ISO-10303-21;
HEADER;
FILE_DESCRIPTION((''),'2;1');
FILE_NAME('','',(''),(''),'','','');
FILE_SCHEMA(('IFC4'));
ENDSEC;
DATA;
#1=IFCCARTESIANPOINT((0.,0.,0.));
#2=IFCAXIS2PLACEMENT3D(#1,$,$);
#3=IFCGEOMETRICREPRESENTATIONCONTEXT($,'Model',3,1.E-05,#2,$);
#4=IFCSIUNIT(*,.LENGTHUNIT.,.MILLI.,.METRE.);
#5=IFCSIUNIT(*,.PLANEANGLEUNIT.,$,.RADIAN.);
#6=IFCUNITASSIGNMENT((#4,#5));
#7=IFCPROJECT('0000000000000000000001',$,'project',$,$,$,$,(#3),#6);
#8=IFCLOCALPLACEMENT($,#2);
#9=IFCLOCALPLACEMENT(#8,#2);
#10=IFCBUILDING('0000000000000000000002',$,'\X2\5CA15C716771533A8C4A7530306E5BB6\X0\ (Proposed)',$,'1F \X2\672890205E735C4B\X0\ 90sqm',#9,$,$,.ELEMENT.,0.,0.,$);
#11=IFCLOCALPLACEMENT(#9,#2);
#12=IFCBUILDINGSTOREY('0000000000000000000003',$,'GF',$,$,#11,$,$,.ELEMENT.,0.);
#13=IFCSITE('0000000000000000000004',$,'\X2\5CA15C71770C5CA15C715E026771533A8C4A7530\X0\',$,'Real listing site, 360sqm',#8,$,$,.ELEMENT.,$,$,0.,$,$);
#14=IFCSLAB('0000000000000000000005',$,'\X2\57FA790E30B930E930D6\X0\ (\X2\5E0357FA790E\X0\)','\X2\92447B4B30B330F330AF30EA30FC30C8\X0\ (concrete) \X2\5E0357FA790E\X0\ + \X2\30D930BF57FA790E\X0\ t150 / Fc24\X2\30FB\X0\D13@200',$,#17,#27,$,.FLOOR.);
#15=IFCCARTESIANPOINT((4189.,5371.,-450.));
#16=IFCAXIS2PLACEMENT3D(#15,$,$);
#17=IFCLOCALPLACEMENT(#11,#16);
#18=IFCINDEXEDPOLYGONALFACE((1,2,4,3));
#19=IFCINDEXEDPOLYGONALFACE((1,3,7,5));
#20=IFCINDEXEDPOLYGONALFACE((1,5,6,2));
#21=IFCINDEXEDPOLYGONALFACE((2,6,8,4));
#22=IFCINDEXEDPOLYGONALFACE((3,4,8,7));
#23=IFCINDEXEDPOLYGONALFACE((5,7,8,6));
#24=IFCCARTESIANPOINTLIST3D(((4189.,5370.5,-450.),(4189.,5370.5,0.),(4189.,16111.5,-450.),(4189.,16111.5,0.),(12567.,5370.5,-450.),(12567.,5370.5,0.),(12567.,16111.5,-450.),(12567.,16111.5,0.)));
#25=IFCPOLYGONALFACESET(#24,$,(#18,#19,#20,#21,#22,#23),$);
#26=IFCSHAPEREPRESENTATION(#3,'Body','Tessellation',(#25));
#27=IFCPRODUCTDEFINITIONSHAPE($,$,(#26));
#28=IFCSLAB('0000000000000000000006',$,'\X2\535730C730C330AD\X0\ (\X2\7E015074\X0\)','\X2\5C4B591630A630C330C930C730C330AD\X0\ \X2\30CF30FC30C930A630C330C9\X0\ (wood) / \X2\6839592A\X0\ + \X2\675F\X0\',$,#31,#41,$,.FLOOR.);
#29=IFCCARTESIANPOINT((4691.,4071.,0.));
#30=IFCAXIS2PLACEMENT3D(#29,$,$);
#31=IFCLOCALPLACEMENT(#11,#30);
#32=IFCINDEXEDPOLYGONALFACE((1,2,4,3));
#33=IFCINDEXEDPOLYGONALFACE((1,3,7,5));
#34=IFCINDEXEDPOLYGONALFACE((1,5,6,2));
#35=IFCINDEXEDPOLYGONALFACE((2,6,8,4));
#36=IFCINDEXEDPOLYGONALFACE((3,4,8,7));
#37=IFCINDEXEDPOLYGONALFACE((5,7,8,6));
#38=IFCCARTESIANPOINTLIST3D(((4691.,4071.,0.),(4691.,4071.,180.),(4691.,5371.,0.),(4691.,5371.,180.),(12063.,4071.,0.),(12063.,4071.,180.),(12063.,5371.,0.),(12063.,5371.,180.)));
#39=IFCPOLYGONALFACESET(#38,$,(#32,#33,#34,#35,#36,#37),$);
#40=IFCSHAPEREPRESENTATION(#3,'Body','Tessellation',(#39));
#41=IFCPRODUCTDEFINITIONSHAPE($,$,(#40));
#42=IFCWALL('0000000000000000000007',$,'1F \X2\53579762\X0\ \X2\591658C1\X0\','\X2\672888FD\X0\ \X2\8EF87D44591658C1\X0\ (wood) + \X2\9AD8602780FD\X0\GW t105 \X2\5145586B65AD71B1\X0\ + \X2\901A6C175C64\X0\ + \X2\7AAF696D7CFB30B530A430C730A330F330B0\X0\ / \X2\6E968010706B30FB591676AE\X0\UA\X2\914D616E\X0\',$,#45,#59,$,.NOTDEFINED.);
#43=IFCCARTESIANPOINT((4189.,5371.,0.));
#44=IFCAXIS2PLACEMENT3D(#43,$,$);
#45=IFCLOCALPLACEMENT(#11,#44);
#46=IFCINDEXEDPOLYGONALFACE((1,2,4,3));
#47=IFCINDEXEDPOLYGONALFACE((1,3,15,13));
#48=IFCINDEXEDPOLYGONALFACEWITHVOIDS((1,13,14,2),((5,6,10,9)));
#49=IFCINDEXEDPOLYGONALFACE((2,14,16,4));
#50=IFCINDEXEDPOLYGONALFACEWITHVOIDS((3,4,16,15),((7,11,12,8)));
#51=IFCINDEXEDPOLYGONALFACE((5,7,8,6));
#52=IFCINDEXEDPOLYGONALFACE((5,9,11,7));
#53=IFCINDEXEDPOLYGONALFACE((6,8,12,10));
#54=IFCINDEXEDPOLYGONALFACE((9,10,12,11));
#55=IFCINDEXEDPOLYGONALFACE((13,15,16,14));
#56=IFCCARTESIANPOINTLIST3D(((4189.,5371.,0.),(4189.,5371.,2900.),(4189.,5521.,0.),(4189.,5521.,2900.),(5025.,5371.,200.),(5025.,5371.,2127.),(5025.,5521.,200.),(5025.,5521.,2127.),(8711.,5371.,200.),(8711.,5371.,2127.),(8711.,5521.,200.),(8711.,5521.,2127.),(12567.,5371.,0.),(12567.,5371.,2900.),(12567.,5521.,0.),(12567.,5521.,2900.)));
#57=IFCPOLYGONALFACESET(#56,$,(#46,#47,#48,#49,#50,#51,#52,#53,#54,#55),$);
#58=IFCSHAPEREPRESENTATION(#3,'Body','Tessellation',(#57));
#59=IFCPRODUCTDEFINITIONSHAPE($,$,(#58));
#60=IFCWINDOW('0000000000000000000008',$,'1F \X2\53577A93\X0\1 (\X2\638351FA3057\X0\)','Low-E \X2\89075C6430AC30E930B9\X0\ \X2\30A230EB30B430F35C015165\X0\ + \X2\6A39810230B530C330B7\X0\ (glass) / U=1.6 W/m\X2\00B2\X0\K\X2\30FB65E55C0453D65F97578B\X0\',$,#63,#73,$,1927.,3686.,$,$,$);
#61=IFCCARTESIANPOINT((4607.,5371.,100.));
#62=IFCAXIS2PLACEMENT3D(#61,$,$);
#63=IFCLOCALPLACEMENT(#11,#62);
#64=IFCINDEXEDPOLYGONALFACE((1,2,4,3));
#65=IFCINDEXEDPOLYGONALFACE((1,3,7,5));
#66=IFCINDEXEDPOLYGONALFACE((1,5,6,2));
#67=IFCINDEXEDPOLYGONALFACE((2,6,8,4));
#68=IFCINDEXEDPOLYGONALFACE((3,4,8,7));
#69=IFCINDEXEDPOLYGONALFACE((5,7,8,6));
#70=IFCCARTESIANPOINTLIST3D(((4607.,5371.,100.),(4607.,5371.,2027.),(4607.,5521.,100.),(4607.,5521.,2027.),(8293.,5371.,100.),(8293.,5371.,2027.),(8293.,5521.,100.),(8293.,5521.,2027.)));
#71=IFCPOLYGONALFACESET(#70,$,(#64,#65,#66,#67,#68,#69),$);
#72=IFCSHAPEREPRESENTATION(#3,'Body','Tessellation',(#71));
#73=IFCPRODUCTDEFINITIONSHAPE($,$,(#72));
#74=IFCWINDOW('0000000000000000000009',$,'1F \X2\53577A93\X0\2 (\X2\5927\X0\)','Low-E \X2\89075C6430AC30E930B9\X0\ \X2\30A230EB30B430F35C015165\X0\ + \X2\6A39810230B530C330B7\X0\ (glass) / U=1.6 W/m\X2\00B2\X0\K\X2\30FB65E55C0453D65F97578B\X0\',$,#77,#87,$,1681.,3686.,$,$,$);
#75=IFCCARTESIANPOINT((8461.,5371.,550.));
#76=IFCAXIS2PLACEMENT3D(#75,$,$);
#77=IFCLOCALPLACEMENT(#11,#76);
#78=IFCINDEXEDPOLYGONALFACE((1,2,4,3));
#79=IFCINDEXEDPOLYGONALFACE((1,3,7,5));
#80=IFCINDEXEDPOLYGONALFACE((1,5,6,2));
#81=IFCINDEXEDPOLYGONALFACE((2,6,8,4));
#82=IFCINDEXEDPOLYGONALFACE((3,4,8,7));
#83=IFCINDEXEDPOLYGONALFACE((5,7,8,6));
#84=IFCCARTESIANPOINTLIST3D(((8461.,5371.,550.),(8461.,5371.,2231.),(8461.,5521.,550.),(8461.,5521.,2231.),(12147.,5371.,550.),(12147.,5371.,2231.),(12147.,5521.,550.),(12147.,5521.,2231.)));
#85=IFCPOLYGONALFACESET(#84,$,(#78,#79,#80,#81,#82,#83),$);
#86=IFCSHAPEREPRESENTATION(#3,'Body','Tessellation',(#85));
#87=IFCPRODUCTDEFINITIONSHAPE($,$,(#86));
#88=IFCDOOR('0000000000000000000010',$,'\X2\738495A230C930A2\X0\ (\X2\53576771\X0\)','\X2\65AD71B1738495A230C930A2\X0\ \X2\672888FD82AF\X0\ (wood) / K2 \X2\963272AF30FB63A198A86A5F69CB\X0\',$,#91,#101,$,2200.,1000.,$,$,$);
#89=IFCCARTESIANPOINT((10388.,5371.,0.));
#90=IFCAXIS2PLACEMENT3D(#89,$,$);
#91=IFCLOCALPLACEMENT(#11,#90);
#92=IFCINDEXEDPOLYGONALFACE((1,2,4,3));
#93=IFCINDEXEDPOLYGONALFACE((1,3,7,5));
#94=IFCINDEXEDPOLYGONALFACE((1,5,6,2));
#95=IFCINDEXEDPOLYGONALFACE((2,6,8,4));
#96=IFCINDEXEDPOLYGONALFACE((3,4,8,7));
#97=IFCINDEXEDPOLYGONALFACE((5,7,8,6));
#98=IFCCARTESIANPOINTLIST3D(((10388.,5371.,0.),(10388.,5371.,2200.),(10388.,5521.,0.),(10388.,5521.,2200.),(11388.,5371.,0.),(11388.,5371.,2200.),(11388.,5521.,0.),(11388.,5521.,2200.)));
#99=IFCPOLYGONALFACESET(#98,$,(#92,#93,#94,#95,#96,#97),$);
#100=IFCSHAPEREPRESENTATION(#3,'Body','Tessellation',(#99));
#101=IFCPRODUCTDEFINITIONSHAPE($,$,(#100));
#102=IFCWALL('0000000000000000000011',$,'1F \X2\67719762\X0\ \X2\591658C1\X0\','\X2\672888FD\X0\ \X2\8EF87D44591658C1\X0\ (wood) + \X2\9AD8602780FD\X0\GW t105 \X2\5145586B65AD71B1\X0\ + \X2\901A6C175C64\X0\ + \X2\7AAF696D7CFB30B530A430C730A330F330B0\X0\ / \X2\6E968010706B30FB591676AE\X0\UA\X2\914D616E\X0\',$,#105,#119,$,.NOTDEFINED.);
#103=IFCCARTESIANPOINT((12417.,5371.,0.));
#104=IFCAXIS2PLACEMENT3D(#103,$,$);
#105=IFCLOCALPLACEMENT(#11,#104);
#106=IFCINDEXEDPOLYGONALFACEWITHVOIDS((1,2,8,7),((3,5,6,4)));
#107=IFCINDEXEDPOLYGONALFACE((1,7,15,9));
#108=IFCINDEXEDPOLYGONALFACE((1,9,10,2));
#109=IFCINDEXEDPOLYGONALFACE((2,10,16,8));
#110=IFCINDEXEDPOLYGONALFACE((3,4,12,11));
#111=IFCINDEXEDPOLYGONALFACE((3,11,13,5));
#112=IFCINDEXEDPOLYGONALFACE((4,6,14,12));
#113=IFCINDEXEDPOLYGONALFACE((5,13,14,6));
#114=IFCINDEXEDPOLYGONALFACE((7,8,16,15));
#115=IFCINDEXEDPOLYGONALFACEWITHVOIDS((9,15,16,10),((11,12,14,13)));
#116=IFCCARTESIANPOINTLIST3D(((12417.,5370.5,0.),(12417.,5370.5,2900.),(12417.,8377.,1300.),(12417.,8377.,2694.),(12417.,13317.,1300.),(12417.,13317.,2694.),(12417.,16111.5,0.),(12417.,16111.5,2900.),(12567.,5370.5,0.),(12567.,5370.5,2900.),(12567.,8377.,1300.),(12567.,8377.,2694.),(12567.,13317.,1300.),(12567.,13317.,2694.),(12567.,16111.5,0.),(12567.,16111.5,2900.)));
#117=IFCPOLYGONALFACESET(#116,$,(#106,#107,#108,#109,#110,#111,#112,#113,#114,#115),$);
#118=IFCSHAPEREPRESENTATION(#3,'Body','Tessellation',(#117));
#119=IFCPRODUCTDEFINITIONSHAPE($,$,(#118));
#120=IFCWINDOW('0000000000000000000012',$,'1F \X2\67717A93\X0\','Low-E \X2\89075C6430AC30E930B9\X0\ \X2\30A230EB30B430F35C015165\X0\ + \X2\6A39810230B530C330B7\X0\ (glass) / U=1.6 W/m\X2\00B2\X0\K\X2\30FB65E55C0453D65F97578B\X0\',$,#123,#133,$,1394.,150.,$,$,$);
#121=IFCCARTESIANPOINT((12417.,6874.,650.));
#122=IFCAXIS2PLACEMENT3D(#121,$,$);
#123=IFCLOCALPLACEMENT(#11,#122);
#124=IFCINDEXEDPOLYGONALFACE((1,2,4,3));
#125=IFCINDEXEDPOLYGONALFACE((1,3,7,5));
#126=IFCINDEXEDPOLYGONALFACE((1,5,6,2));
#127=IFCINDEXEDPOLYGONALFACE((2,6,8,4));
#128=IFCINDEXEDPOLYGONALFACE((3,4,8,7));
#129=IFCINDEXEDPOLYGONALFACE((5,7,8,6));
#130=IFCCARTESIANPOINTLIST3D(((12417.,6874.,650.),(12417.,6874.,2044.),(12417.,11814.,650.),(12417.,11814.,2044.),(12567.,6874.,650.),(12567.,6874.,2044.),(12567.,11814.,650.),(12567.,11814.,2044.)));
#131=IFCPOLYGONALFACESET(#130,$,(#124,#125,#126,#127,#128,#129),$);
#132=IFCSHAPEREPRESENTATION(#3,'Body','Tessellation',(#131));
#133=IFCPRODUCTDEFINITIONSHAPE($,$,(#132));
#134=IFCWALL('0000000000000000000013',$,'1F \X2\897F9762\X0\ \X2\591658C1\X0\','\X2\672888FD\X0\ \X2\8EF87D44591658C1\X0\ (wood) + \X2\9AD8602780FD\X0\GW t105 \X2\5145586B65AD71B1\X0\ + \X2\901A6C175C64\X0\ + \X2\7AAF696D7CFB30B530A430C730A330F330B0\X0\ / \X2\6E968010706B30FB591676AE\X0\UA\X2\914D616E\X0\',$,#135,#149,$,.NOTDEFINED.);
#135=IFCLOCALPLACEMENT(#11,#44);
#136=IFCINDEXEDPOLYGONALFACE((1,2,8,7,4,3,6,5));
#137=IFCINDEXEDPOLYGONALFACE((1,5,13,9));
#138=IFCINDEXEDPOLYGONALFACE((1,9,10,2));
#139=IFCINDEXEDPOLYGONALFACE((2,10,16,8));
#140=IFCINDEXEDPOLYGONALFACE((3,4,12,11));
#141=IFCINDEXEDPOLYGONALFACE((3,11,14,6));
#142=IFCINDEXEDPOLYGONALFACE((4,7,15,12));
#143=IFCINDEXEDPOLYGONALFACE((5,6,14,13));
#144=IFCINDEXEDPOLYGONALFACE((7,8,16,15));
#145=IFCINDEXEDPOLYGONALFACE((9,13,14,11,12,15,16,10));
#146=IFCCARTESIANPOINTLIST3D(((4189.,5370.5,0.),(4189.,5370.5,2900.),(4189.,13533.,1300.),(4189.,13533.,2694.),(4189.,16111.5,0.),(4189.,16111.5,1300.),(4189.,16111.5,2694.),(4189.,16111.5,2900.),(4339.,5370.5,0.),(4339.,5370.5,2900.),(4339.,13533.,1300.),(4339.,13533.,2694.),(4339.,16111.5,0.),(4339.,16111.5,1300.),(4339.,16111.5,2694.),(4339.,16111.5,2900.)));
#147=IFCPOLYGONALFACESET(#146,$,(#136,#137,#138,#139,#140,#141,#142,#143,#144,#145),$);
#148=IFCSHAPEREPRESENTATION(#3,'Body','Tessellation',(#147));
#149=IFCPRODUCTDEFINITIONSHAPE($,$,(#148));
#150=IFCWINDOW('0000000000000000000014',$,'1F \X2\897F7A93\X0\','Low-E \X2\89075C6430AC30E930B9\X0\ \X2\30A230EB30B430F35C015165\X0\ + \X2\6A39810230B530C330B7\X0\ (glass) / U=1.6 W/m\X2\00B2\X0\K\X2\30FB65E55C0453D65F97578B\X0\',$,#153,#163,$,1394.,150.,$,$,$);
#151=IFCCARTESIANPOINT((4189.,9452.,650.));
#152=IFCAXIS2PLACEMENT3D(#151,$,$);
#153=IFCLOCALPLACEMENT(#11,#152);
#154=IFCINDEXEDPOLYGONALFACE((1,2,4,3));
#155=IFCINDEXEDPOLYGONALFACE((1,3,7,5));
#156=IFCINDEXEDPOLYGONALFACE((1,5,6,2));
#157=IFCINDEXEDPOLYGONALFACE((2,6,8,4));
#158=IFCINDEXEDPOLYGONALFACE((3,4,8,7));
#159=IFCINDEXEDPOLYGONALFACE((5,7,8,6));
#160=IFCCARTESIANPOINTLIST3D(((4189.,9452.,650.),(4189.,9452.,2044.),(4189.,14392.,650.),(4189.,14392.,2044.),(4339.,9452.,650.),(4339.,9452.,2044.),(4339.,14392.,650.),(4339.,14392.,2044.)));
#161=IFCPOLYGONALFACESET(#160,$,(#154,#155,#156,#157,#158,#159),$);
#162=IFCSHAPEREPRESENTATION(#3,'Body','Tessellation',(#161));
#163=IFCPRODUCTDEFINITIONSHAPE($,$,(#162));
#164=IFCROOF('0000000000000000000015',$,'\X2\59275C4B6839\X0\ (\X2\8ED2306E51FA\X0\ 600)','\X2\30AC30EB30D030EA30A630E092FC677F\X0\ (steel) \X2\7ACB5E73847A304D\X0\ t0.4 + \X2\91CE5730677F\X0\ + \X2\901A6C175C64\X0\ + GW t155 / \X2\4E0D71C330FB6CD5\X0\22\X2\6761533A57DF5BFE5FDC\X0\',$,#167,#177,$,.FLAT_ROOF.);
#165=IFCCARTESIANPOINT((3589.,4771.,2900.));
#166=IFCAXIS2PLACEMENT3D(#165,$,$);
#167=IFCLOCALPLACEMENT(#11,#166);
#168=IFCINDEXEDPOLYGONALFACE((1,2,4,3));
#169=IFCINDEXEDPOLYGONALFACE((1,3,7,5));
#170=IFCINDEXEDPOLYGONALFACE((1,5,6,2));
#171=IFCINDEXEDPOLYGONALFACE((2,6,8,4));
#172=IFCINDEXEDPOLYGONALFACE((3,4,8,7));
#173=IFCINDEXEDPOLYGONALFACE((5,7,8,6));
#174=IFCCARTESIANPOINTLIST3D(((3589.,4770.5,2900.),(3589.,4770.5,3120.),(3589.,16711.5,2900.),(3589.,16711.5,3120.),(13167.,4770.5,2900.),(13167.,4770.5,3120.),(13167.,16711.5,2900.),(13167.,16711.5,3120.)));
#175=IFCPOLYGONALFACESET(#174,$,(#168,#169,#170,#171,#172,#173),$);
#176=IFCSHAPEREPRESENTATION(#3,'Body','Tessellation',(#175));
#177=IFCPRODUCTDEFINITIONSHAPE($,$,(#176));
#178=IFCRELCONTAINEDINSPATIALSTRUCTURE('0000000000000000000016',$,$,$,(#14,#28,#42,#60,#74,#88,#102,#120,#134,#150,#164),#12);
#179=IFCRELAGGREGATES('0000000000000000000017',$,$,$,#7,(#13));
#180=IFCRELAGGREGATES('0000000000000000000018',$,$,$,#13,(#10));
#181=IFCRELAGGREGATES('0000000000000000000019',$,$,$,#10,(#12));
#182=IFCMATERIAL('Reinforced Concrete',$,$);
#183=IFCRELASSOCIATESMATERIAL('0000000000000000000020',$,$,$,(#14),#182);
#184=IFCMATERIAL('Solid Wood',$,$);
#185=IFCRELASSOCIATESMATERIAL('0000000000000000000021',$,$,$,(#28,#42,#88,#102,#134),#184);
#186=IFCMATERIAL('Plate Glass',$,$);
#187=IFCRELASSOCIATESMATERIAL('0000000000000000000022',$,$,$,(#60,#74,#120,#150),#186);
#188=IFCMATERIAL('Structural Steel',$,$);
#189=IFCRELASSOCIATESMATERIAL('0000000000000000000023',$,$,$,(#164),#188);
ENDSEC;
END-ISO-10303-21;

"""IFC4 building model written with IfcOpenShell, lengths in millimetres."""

from ifc_helpers import new_model, si_unit, frame, frame_2d, origin, place, context, project, spatial, rectangle, extrude, material, element, fill, save


model = new_model("IFC4")

# Units and contexts
model_context = context("Model", 3, precision=1e-05, world=origin())
ifc_project = project(units=[si_unit("LENGTHUNIT", "METRE", prefix="MILLI"), si_unit("PLANEANGLEUNIT", "RADIAN")], contexts=[model_context])

# Site, building, storey
site_placement = place(None, origin())
site = spatial("IfcSite", under=ifc_project, at=site_placement, Name="岡山県岡山市東区豊田", ObjectType="Real listing site, 360sqm", CompositionType="ELEMENT", RefElevation=0.0)
building_placement = place(site_placement, origin())
building = spatial("IfcBuilding", under=site, at=building_placement, Name="岡山東区豊田の家 (Proposed)", ObjectType="1F 木造平屋 90sqm", CompositionType="ELEMENT", ElevationOfRefHeight=0.0, ElevationOfTerrain=0.0)
storey_placement = place(building_placement, origin())
storey = spatial("IfcBuildingStorey", under=building, at=storey_placement, Name="GF", CompositionType="ELEMENT", Elevation=0.0)

# Slabs
ifc_material_1 = material(Name="Reinforced Concrete")
slab_1_placement = place(storey_placement, frame((4189.0, 5371.0, -450.0)))
element("IfcSlab", 1, at=slab_1_placement, inside=storey, material=ifc_material_1, Name="基礎スラブ (布基礎)", Description="鉄筋コンクリート (concrete) 布基礎 + ベタ基礎 t150 / Fc24・D13@200", PredefinedType="FLOOR", context=model_context, shape_type="SweptSolid", body=[
    extrude(rectangle(XDim=8378.0, YDim=10741.0, at=frame_2d((4189.0, 5370.0))), frame((4189.0, 5371.0, -450.0)), (0.0, 0.0, 1.0), 450.0),
])
ifc_material_2 = material(Name="Solid Wood")
slab_2_placement = place(storey_placement, frame((4691.0, 4071.0, 0.0)))
element("IfcSlab", 2, at=slab_2_placement, inside=storey, material=ifc_material_2, Name="南デッキ (縁側)", Description="屋外ウッドデッキ ハードウッド (wood) / 根太 + 束", PredefinedType="FLOOR", context=model_context, shape_type="SweptSolid", body=[
    extrude(rectangle(XDim=7372.0, YDim=1300.0, at=frame_2d((3686.0, 650.0))), frame((4691.0, 4071.0, 0.0)), (0.0, 0.0, 1.0), 180.0),
])

# Wall, openings, windows, door
wall_1_placement = place(storey_placement, frame((4189.0, 5371.0, 0.0)))
wall_1 = element("IfcWall", 3, at=wall_1_placement, inside=storey, material=ifc_material_2, Name="1F 南面 外壁", Description="木製 軸組外壁 (wood) + 高性能GW t105 充填断熱 + 通気層 + 窯業系サイディング / 準耐火・外皮UA配慮", PredefinedType="NOTDEFINED", context=model_context, shape_type="SweptSolid", body=[
    extrude(rectangle(XDim=8378.0, YDim=150.0, at=frame_2d((4189.0, 75.0))), frame((4189.0, 5371.0, 0.0)), (0.0, 0.0, 1.0), 2900.0),
])
opening_1_placement = place(storey_placement, frame((4607.0, 5371.0, 100.0)))
opening_1 = element("IfcOpeningElement", 4, at=opening_1_placement, cuts=wall_1, PredefinedType="NOTDEFINED", context=model_context, shape_type="SweptSolid", body=[
    extrude(rectangle(XDim=3686.0, YDim=150.0, at=frame_2d((1843.0, 75.0))), frame((4607.0, 5371.0, 100.0)), (0.0, 0.0, 1.0), 1927.0),
])
opening_2_placement = place(storey_placement, frame((8461.0, 5371.0, 550.0)))
opening_2 = element("IfcOpeningElement", 5, at=opening_2_placement, cuts=wall_1, PredefinedType="NOTDEFINED", context=model_context, shape_type="SweptSolid", body=[
    extrude(rectangle(XDim=3686.0, YDim=150.0, at=frame_2d((1843.0, 75.0))), frame((8461.0, 5371.0, 550.0)), (0.0, 0.0, 1.0), 1681.0),
])
opening_3_placement = place(storey_placement, frame((10388.0, 5371.0, 0.0)))
opening_3 = element("IfcOpeningElement", 6, at=opening_3_placement, cuts=wall_1, PredefinedType="NOTDEFINED", context=model_context, shape_type="SweptSolid", body=[
    extrude(rectangle(XDim=1000.0, YDim=150.0, at=frame_2d((500.0, 75.0))), frame((10388.0, 5371.0, 0.0)), (0.0, 0.0, 1.0), 2200.0),
])
ifc_material_3 = material(Name="Plate Glass")
window_1_placement = place(storey_placement, frame((4607.0, 5371.0, 100.0)))
window_1 = element("IfcWindow", 7, at=window_1_placement, inside=storey, material=ifc_material_3, Name="1F 南窓1 (掃出し)", Description="Low-E 複層ガラス アルゴン封入 + 樹脂サッシ (glass) / U=1.6 W/m²K・日射取得型", OverallHeight=1927.0, OverallWidth=3686.0, context=model_context, shape_type="SweptSolid", body=[
    extrude(rectangle(XDim=3686.0, YDim=150.0, at=frame_2d((1843.0, 75.0))), frame((4607.0, 5371.0, 100.0)), (0.0, 0.0, 1.0), 1927.0),
])
fill(opening_1, window_1)
window_2_placement = place(storey_placement, frame((8461.0, 5371.0, 550.0)))
window_2 = element("IfcWindow", 8, at=window_2_placement, inside=storey, material=ifc_material_3, Name="1F 南窓2 (大)", Description="Low-E 複層ガラス アルゴン封入 + 樹脂サッシ (glass) / U=1.6 W/m²K・日射取得型", OverallHeight=1681.0, OverallWidth=3686.0, context=model_context, shape_type="SweptSolid", body=[
    extrude(rectangle(XDim=3686.0, YDim=150.0, at=frame_2d((1843.0, 75.0))), frame((8461.0, 5371.0, 550.0)), (0.0, 0.0, 1.0), 1681.0),
])
fill(opening_2, window_2)
door_placement = place(storey_placement, frame((10388.0, 5371.0, 0.0)))
door = element("IfcDoor", 9, at=door_placement, inside=storey, material=ifc_material_2, Name="玄関ドア (南東)", Description="断熱玄関ドア 木製芯 (wood) / K2 防犯・採風機構", OverallHeight=2200.0, OverallWidth=1000.0, context=model_context, shape_type="SweptSolid", body=[
    extrude(rectangle(XDim=1000.0, YDim=150.0, at=frame_2d((500.0, 75.0))), frame((10388.0, 5371.0, 0.0)), (0.0, 0.0, 1.0), 2200.0),
])
fill(opening_3, door)

# Walls, openings, windows
wall_2_placement = place(storey_placement, frame((12417.0, 5371.0, 0.0)))
wall_2 = element("IfcWall", 10, at=wall_2_placement, inside=storey, material=ifc_material_2, Name="1F 東面 外壁", Description="木製 軸組外壁 (wood) + 高性能GW t105 充填断熱 + 通気層 + 窯業系サイディング / 準耐火・外皮UA配慮", PredefinedType="NOTDEFINED", context=model_context, shape_type="SweptSolid", body=[
    extrude(rectangle(XDim=150.0, YDim=10741.0, at=frame_2d((75.0, 5370.0))), frame((12417.0, 5371.0, 0.0)), (0.0, 0.0, 1.0), 2900.0),
])
opening_4_placement = place(storey_placement, frame((12417.0, 6874.0, 650.0)))
opening_4 = element("IfcOpeningElement", 11, at=opening_4_placement, cuts=wall_2, PredefinedType="NOTDEFINED", context=model_context, shape_type="SweptSolid", body=[
    extrude(rectangle(XDim=150.0, YDim=4940.0, at=frame_2d((75.0, 2470.0))), frame((12417.0, 6874.0, 650.0)), (0.0, 0.0, 1.0), 1394.0),
])
window_3_placement = place(storey_placement, frame((12417.0, 6874.0, 650.0)))
window_3 = element("IfcWindow", 12, at=window_3_placement, inside=storey, material=ifc_material_3, Name="1F 東窓", Description="Low-E 複層ガラス アルゴン封入 + 樹脂サッシ (glass) / U=1.6 W/m²K・日射取得型", OverallHeight=1394.0, OverallWidth=150.0, context=model_context, shape_type="SweptSolid", body=[
    extrude(rectangle(XDim=150.0, YDim=4940.0, at=frame_2d((75.0, 2470.0))), frame((12417.0, 6874.0, 650.0)), (0.0, 0.0, 1.0), 1394.0),
])
fill(opening_4, window_3)
wall_3_placement = place(storey_placement, frame((4189.0, 5371.0, 0.0)))
wall_3 = element("IfcWall", 13, at=wall_3_placement, inside=storey, material=ifc_material_2, Name="1F 西面 外壁", Description="木製 軸組外壁 (wood) + 高性能GW t105 充填断熱 + 通気層 + 窯業系サイディング / 準耐火・外皮UA配慮", PredefinedType="NOTDEFINED", context=model_context, shape_type="SweptSolid", body=[
    extrude(rectangle(XDim=150.0, YDim=10741.0, at=frame_2d((75.0, 5370.0))), frame((4189.0, 5371.0, 0.0)), (0.0, 0.0, 1.0), 2900.0),
])
opening_5_placement = place(storey_placement, frame((4189.0, 9452.0, 650.0)))
opening_5 = element("IfcOpeningElement", 14, at=opening_5_placement, cuts=wall_3, PredefinedType="NOTDEFINED", context=model_context, shape_type="SweptSolid", body=[
    extrude(rectangle(XDim=150.0, YDim=4940.0, at=frame_2d((75.0, 2470.0))), frame((4189.0, 9452.0, 650.0)), (0.0, 0.0, 1.0), 1394.0),
])
window_4_placement = place(storey_placement, frame((4189.0, 9452.0, 650.0)))
window_4 = element("IfcWindow", 15, at=window_4_placement, inside=storey, material=ifc_material_3, Name="1F 西窓", Description="Low-E 複層ガラス アルゴン封入 + 樹脂サッシ (glass) / U=1.6 W/m²K・日射取得型", OverallHeight=1394.0, OverallWidth=150.0, context=model_context, shape_type="SweptSolid", body=[
    extrude(rectangle(XDim=150.0, YDim=4940.0, at=frame_2d((75.0, 2470.0))), frame((4189.0, 9452.0, 650.0)), (0.0, 0.0, 1.0), 1394.0),
])
fill(opening_5, window_4)

# Roof
ifc_material_4 = material(Name="Structural Steel")
roof_placement = place(storey_placement, frame((3589.0, 4771.0, 2900.0)))
element("IfcRoof", 16, at=roof_placement, inside=storey, material=ifc_material_4, Name="大屋根 (軒の出 600)", Description="ガルバリウム鋼板 (steel) 立平葺き t0.4 + 野地板 + 通気層 + GW t155 / 不燃・法22条区域対応", PredefinedType="FLAT_ROOF", context=model_context, shape_type="SweptSolid", body=[
    extrude(rectangle(XDim=9578.0, YDim=11941.0, at=frame_2d((4789.0, 5970.0))), frame((3589.0, 4771.0, 2900.0)), (0.0, 0.0, 1.0), 220.0),
])

save(model, "model.ifc")
